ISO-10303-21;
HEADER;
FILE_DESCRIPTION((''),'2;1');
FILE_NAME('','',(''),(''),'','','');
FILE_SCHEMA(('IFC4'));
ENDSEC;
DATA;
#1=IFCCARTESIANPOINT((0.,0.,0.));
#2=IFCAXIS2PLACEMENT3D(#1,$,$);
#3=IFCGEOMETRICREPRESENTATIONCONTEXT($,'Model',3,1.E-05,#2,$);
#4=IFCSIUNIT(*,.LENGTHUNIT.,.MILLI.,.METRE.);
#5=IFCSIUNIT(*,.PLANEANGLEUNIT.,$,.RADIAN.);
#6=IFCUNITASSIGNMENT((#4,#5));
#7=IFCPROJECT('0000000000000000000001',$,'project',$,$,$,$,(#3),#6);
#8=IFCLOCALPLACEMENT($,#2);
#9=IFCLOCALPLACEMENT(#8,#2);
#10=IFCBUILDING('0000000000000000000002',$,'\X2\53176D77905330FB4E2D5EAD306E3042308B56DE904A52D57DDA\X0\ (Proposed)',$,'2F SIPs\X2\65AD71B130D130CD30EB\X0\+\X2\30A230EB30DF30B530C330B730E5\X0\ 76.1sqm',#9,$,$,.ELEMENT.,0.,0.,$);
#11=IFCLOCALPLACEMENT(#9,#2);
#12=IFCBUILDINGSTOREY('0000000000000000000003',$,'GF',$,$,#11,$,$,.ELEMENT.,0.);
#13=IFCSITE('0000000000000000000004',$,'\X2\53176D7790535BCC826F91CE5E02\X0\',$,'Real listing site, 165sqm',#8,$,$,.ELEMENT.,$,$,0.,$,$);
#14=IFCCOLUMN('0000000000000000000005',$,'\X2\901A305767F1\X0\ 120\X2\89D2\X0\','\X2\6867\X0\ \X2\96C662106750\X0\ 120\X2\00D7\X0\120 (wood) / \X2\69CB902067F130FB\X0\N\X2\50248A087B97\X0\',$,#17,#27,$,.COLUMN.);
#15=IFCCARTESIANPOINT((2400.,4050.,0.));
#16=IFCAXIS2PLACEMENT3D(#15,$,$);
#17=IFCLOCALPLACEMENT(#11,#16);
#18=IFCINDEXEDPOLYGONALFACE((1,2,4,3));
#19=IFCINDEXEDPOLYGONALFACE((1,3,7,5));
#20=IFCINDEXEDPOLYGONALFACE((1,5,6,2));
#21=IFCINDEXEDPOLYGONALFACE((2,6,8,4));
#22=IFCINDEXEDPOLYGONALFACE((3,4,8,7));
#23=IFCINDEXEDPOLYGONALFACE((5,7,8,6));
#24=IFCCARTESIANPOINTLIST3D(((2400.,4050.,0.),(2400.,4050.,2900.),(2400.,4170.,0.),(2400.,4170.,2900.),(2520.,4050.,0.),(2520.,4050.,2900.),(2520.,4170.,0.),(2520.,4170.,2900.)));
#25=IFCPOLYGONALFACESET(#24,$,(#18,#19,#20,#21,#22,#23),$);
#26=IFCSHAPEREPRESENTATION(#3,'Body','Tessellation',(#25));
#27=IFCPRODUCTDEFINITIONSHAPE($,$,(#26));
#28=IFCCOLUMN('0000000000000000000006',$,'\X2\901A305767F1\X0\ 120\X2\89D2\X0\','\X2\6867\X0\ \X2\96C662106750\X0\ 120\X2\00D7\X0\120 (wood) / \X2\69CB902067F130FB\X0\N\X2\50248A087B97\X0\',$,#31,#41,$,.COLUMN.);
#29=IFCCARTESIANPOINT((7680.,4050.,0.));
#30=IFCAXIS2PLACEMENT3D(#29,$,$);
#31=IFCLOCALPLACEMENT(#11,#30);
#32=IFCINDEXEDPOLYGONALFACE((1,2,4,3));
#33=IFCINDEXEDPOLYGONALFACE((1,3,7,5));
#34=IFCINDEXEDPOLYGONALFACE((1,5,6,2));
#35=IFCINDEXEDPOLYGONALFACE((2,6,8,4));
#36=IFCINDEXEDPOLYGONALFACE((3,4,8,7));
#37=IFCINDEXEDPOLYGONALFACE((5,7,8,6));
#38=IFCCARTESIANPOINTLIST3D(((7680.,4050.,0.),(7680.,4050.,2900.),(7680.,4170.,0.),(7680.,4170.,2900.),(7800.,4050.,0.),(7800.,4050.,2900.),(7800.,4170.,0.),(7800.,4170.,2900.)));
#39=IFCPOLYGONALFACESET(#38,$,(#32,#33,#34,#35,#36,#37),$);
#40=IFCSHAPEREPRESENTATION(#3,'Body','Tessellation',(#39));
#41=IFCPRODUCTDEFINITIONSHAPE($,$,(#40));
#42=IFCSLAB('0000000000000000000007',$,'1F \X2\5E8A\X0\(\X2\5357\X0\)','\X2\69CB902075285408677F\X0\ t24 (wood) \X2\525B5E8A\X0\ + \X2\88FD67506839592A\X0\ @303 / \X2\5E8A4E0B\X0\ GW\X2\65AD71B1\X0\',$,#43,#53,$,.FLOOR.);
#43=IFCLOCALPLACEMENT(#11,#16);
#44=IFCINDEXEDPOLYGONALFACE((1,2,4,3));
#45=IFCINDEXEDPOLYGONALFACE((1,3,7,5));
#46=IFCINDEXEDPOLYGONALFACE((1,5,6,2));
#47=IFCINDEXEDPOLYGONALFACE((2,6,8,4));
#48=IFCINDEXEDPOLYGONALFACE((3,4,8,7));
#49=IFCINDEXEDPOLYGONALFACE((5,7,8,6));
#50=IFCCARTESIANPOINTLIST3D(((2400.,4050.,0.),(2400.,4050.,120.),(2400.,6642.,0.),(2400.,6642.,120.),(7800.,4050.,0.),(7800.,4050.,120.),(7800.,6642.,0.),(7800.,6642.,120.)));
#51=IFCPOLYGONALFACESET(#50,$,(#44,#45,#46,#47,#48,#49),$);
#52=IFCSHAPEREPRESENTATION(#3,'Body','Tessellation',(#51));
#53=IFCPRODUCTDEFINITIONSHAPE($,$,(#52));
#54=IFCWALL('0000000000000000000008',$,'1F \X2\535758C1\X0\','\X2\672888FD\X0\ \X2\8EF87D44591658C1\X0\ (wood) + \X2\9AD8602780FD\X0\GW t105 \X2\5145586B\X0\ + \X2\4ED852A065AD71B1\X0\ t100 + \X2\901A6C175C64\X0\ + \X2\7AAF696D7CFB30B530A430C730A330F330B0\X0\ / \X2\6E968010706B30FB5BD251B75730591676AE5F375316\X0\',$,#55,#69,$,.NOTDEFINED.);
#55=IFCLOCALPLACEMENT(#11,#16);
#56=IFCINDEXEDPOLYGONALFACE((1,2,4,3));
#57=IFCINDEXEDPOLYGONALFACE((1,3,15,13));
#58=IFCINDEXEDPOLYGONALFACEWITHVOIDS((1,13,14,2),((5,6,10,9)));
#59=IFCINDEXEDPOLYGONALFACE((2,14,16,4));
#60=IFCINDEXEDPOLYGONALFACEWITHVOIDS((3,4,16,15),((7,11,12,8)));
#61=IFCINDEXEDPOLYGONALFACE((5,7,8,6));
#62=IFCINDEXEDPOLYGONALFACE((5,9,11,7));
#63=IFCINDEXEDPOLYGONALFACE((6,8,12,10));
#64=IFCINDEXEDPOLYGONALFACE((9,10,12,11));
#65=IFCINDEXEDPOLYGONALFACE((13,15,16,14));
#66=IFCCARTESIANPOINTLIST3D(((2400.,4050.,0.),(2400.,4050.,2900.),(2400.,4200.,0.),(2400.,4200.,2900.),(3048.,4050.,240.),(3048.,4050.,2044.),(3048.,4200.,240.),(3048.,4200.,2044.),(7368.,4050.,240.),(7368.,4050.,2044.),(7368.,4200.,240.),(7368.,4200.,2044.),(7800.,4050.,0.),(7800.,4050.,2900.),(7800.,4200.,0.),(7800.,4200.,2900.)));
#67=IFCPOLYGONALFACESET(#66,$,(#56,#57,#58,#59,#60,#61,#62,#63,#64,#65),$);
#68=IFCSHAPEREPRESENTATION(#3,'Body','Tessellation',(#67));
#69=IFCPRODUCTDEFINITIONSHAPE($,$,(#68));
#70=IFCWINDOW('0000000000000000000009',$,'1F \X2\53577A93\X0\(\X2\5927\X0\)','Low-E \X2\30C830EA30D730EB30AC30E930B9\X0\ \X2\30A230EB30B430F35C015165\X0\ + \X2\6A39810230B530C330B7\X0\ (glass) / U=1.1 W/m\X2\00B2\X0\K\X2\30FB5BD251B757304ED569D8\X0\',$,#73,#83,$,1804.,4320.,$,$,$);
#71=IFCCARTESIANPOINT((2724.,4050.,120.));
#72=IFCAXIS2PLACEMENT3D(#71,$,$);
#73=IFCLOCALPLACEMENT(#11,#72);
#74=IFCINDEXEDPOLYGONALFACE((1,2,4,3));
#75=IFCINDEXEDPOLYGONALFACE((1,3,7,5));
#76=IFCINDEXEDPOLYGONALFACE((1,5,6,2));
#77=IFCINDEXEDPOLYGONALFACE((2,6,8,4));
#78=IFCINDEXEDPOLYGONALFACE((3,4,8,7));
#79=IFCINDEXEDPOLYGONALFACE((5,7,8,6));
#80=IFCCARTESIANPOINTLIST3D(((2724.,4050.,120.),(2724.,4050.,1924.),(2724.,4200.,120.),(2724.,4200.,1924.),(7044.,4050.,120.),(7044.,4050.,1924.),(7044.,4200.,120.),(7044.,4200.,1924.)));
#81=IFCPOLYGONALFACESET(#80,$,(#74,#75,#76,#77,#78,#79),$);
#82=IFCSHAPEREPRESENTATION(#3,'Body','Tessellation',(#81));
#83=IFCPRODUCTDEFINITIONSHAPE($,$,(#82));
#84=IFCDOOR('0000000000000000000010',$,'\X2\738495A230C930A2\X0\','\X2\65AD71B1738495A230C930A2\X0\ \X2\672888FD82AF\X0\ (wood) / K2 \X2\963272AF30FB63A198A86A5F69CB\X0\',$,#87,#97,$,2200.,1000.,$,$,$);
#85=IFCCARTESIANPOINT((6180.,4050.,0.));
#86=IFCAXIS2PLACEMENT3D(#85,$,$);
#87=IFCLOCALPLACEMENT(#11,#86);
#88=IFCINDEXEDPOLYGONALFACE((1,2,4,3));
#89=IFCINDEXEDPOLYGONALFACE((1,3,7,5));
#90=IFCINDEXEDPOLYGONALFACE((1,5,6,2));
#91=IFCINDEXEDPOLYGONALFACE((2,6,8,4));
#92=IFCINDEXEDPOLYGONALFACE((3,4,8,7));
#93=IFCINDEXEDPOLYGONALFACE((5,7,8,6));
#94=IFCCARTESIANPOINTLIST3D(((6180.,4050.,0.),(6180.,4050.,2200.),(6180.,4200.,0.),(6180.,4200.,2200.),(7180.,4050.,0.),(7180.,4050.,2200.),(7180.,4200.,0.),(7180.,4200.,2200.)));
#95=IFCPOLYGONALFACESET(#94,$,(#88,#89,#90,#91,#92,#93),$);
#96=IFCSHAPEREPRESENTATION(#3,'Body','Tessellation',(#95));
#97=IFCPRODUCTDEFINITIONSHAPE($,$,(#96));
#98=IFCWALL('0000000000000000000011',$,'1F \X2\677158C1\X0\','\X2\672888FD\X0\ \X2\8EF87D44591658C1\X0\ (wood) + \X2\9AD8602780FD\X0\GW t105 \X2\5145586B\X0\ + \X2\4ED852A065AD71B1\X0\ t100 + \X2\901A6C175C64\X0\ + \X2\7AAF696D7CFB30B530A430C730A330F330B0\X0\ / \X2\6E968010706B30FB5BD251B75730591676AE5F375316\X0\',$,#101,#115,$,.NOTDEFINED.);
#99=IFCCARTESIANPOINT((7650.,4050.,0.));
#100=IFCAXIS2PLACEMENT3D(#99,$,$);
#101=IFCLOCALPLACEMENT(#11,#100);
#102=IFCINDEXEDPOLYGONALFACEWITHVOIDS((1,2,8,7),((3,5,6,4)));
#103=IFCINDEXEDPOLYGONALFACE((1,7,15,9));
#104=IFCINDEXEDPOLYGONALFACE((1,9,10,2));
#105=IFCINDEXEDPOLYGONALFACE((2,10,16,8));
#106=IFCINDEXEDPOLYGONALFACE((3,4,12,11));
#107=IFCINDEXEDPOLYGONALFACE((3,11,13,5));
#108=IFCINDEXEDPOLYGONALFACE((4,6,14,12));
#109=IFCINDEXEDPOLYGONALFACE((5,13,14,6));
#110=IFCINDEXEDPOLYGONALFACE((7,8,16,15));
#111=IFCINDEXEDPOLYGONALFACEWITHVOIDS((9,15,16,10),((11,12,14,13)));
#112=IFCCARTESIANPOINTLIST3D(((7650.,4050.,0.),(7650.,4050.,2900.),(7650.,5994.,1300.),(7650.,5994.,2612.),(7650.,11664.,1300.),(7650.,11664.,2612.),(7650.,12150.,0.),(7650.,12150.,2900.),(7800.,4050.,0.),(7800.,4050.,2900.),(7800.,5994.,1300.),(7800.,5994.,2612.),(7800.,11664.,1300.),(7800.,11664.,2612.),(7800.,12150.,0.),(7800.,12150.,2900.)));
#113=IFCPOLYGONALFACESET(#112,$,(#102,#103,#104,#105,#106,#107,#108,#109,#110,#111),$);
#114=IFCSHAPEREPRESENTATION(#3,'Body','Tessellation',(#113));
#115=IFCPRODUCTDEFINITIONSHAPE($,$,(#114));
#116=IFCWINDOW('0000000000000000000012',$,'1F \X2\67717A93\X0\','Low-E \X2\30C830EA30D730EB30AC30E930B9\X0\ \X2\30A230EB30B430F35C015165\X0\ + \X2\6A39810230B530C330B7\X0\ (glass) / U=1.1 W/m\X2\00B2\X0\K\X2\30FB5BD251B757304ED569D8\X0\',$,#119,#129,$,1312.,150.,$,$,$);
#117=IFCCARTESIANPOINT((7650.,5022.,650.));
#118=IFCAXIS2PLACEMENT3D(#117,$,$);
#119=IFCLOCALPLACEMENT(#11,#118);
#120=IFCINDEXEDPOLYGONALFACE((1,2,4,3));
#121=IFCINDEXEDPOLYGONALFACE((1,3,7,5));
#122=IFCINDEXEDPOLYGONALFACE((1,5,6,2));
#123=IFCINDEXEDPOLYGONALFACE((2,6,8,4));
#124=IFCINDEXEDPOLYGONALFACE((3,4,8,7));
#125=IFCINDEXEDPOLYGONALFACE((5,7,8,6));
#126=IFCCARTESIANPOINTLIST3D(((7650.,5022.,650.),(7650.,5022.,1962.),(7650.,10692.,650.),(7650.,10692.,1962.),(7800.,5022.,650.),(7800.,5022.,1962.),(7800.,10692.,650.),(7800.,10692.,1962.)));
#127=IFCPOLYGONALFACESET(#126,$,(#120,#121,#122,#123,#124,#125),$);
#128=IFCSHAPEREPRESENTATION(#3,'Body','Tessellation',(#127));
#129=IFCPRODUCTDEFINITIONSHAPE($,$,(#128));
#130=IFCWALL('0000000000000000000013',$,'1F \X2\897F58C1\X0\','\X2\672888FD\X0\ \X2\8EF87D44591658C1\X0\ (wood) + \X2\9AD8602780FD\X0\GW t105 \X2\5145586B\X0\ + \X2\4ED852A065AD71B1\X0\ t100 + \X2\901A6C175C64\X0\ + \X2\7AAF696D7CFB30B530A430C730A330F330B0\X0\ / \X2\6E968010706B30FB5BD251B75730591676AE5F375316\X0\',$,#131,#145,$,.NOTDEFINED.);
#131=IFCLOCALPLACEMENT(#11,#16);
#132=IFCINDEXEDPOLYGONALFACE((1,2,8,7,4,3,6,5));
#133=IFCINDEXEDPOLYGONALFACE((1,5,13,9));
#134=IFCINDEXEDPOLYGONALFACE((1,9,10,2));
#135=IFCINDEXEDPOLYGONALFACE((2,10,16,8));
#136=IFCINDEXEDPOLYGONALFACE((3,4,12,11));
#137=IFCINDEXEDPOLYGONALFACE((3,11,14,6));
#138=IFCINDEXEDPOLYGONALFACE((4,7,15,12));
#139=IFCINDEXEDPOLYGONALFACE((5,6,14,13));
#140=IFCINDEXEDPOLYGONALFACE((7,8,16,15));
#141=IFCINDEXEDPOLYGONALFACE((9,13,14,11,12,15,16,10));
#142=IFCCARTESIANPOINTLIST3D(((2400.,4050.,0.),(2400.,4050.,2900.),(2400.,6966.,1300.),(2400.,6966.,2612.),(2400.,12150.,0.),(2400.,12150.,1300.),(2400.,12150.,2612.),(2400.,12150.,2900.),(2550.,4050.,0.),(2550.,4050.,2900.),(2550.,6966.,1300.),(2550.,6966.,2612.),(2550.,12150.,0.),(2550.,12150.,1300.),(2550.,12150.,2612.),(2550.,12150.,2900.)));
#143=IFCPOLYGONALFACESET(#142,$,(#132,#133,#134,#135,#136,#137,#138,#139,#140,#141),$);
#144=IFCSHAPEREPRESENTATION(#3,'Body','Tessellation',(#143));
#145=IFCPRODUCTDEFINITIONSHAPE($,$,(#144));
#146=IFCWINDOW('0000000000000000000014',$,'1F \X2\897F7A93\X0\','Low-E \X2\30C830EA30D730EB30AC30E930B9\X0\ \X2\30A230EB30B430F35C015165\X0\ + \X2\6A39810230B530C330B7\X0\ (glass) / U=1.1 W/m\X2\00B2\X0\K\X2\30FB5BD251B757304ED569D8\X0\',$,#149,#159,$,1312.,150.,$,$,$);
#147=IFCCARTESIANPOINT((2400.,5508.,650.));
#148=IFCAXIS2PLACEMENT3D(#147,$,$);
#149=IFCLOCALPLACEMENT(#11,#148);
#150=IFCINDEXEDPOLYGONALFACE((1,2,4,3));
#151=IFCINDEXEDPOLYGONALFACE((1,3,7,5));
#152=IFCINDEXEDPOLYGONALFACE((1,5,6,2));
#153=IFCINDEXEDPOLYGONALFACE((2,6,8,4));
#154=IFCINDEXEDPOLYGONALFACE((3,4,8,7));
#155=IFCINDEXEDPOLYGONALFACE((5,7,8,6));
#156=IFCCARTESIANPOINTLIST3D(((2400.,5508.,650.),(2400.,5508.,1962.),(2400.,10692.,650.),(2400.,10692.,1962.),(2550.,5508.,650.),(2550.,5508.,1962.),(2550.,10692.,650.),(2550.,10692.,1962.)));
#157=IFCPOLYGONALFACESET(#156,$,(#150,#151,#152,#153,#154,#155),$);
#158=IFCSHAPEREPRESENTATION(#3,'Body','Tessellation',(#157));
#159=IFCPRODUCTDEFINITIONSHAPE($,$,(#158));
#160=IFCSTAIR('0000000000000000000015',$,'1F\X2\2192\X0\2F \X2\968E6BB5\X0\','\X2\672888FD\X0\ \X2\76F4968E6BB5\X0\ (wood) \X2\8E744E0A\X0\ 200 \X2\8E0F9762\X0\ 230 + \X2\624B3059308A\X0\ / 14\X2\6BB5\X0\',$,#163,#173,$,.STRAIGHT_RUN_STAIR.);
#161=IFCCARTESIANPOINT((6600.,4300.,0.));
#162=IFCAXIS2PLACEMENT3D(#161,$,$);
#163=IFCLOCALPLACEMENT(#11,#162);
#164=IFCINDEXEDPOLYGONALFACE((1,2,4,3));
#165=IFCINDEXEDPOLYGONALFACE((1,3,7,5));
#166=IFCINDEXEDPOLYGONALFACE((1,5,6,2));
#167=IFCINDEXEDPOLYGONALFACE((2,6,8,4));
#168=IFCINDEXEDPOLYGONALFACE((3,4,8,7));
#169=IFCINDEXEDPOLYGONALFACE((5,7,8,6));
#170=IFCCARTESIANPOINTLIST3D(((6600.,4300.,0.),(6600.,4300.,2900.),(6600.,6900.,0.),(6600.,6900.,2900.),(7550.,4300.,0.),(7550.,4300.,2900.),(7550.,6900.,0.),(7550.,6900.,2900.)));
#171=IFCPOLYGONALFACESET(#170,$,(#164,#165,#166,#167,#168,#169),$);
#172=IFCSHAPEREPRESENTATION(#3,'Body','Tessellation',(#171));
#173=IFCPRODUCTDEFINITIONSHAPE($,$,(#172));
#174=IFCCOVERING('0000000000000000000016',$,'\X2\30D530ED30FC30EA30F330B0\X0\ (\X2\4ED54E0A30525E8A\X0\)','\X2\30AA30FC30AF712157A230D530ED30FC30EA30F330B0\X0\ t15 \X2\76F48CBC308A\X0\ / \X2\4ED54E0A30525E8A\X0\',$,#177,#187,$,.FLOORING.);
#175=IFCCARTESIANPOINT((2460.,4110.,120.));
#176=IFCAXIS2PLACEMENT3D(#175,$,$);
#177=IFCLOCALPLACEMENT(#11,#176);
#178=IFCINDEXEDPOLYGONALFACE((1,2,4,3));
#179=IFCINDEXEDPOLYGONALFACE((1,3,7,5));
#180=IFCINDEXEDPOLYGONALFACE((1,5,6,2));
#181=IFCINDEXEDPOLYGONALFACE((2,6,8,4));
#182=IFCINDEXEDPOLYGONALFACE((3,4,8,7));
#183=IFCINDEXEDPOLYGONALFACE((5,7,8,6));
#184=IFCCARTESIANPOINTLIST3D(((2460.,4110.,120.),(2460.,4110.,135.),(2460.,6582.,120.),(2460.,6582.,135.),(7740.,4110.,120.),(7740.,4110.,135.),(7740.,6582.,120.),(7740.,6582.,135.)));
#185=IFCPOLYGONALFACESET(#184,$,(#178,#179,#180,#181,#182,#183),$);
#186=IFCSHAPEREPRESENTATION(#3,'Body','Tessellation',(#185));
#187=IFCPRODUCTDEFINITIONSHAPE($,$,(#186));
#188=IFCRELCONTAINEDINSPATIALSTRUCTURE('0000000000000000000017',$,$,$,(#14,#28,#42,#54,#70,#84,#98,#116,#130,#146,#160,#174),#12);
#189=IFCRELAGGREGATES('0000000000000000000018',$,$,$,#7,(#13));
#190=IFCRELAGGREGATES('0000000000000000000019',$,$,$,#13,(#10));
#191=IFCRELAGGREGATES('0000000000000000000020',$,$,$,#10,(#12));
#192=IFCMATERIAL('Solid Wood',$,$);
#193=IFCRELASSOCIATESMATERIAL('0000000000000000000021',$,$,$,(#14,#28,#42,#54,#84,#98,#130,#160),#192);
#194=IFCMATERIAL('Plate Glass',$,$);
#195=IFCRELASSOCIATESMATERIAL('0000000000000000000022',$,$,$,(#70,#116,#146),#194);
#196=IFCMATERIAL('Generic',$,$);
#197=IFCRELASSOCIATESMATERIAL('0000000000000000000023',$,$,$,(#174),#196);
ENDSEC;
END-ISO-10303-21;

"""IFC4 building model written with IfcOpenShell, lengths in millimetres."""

from ifc_helpers import new_model, si_unit, frame, frame_2d, origin, place, context, project, spatial, rectangle, extrude, material, element, fill, save


model = new_model("IFC4")

# Units and contexts
model_context = context("Model", 3, precision=1e-05, world=origin())
ifc_project = project(units=[si_unit("LENGTHUNIT", "METRE", prefix="MILLI"), si_unit("PLANEANGLEUNIT", "RADIAN")], contexts=[model_context])

# Site, building, storey
site_placement = place(None, origin())
site = spatial("IfcSite", under=ifc_project, at=site_placement, Name="北海道富良野市", ObjectType="Real listing site, 165sqm", CompositionType="ELEMENT", RefElevation=0.0)
building_placement = place(site_placement, origin())
building = spatial("IfcBuilding", under=site, at=building_placement, Name="北海道・中庭のある回遊動線 (Proposed)", ObjectType="2F SIPs断熱パネル+アルミサッシュ 76.1sqm", CompositionType="ELEMENT", ElevationOfRefHeight=0.0, ElevationOfTerrain=0.0)
storey_placement = place(building_placement, origin())
storey = spatial("IfcBuildingStorey", under=building, at=storey_placement, Name="GF", CompositionType="ELEMENT", Elevation=0.0)

# Columns
ifc_material_1 = material(Name="Solid Wood")
column_1_placement = place(storey_placement, frame((2400.0, 4050.0, 0.0)))
element("IfcColumn", 1, at=column_1_placement, inside=storey, material=ifc_material_1, Name="通し柱 120角", Description="桧 集成材 120×120 (wood) / 構造柱・N値計算", PredefinedType="COLUMN", context=model_context, shape_type="SweptSolid", body=[
    extrude(rectangle(XDim=120.0, YDim=120.0, at=frame_2d((60.0, 60.0))), frame((2400.0, 4050.0, 0.0)), (0.0, 0.0, 1.0), 2900.0),
])
column_2_placement = place(storey_placement, frame((7680.0, 4050.0, 0.0)))
element("IfcColumn", 2, at=column_2_placement, inside=storey, material=ifc_material_1, Name="通し柱 120角", Description="桧 集成材 120×120 (wood) / 構造柱・N値計算", PredefinedType="COLUMN", context=model_context, shape_type="SweptSolid", body=[
    extrude(rectangle(XDim=120.0, YDim=120.0, at=frame_2d((60.0, 60.0))), frame((7680.0, 4050.0, 0.0)), (0.0, 0.0, 1.0), 2900.0),
])

# Slab
slab_1_placement = place(storey_placement, frame((2400.0, 4050.0, 0.0)))
element("IfcSlab", 3, at=slab_1_placement, inside=storey, material=ifc_material_1, Name="1F 床(南)", Description="構造用合板 t24 (wood) 剛床 + 製材根太 @303 / 床下 GW断熱", PredefinedType="FLOOR", context=model_context, shape_type="SweptSolid", body=[
    extrude(rectangle(XDim=5400.0, YDim=2592.0, at=frame_2d((2700.0, 1296.0))), frame((2400.0, 4050.0, 0.0)), (0.0, 0.0, 1.0), 120.0),
])

# Wall, openings, window, door
wall_1_placement = place(storey_placement, frame((2400.0, 4050.0, 0.0)))
wall_1 = element("IfcWall", 4, at=wall_1_placement, inside=storey, material=ifc_material_1, Name="1F 南壁", Description="木製 軸組外壁 (wood) + 高性能GW t105 充填 + 付加断熱 t100 + 通気層 + 窯業系サイディング / 準耐火・寒冷地外皮強化", PredefinedType="NOTDEFINED", context=model_context, shape_type="SweptSolid", body=[
    extrude(rectangle(XDim=5400.0, YDim=150.0, at=frame_2d((2700.0, 75.0))), frame((2400.0, 4050.0, 0.0)), (0.0, 0.0, 1.0), 2900.0),
])
opening_1_placement = place(storey_placement, frame((2724.0, 4050.0, 120.0)))
opening_1 = element("IfcOpeningElement", 5, at=opening_1_placement, cuts=wall_1, PredefinedType="NOTDEFINED", context=model_context, shape_type="SweptSolid", body=[
    extrude(rectangle(XDim=4320.0, YDim=150.0, at=frame_2d((2160.0, 75.0))), frame((2724.0, 4050.0, 120.0)), (0.0, 0.0, 1.0), 1804.0),
])
opening_2_placement = place(storey_placement, frame((6180.0, 4050.0, 0.0)))
opening_2 = element("IfcOpeningElement", 6, at=opening_2_placement, cuts=wall_1, PredefinedType="NOTDEFINED", context=model_context, shape_type="SweptSolid", body=[
    extrude(rectangle(XDim=1000.0, YDim=150.0, at=frame_2d((500.0, 75.0))), frame((6180.0, 4050.0, 0.0)), (0.0, 0.0, 1.0), 2200.0),
])
ifc_material_2 = material(Name="Plate Glass")
window_1_placement = place(storey_placement, frame((2724.0, 4050.0, 120.0)))
window_1 = element("IfcWindow", 7, at=window_1_placement, inside=storey, material=ifc_material_2, Name="1F 南窓(大)", Description="Low-E トリプルガラス アルゴン封入 + 樹脂サッシ (glass) / U=1.1 W/m²K・寒冷地仕様", OverallHeight=1804.0, OverallWidth=4320.0, context=model_context, shape_type="SweptSolid", body=[
    extrude(rectangle(XDim=4320.0, YDim=150.0, at=frame_2d((2160.0, 75.0))), frame((2724.0, 4050.0, 120.0)), (0.0, 0.0, 1.0), 1804.0),
])
fill(opening_1, window_1)
door_placement = place(storey_placement, frame((6180.0, 4050.0, 0.0)))
door = element("IfcDoor", 8, at=door_placement, inside=storey, material=ifc_material_1, Name="玄関ドア", Description="断熱玄関ドア 木製芯 (wood) / K2 防犯・採風機構", OverallHeight=2200.0, OverallWidth=1000.0, context=model_context, shape_type="SweptSolid", body=[
    extrude(rectangle(XDim=1000.0, YDim=150.0, at=frame_2d((500.0, 75.0))), frame((6180.0, 4050.0, 0.0)), (0.0, 0.0, 1.0), 2200.0),
])
fill(opening_2, door)

# Walls, openings, windows
wall_2_placement = place(storey_placement, frame((7650.0, 4050.0, 0.0)))
wall_2 = element("IfcWall", 9, at=wall_2_placement, inside=storey, material=ifc_material_1, Name="1F 東壁", Description="木製 軸組外壁 (wood) + 高性能GW t105 充填 + 付加断熱 t100 + 通気層 + 窯業系サイディング / 準耐火・寒冷地外皮強化", PredefinedType="NOTDEFINED", context=model_context, shape_type="SweptSolid", body=[
    extrude(rectangle(XDim=150.0, YDim=8100.0, at=frame_2d((75.0, 4050.0))), frame((7650.0, 4050.0, 0.0)), (0.0, 0.0, 1.0), 2900.0),
])
opening_3_placement = place(storey_placement, frame((7650.0, 5022.0, 650.0)))
opening_3 = element("IfcOpeningElement", 10, at=opening_3_placement, cuts=wall_2, PredefinedType="NOTDEFINED", context=model_context, shape_type="SweptSolid", body=[
    extrude(rectangle(XDim=150.0, YDim=5670.0, at=frame_2d((75.0, 2835.0))), frame((7650.0, 5022.0, 650.0)), (0.0, 0.0, 1.0), 1312.0),
])
window_2_placement = place(storey_placement, frame((7650.0, 5022.0, 650.0)))
window_2 = element("IfcWindow", 11, at=window_2_placement, inside=storey, material=ifc_material_2, Name="1F 東窓", Description="Low-E トリプルガラス アルゴン封入 + 樹脂サッシ (glass) / U=1.1 W/m²K・寒冷地仕様", OverallHeight=1312.0, OverallWidth=150.0, context=model_context, shape_type="SweptSolid", body=[
    extrude(rectangle(XDim=150.0, YDim=5670.0, at=frame_2d((75.0, 2835.0))), frame((7650.0, 5022.0, 650.0)), (0.0, 0.0, 1.0), 1312.0),
])
fill(opening_3, window_2)
wall_3_placement = place(storey_placement, frame((2400.0, 4050.0, 0.0)))
wall_3 = element("IfcWall", 12, at=wall_3_placement, inside=storey, material=ifc_material_1, Name="1F 西壁", Description="木製 軸組外壁 (wood) + 高性能GW t105 充填 + 付加断熱 t100 + 通気層 + 窯業系サイディング / 準耐火・寒冷地外皮強化", PredefinedType="NOTDEFINED", context=model_context, shape_type="SweptSolid", body=[
    extrude(rectangle(XDim=150.0, YDim=8100.0, at=frame_2d((75.0, 4050.0))), frame((2400.0, 4050.0, 0.0)), (0.0, 0.0, 1.0), 2900.0),
])
opening_4_placement = place(storey_placement, frame((2400.0, 5508.0, 650.0)))
opening_4 = element("IfcOpeningElement", 13, at=opening_4_placement, cuts=wall_3, PredefinedType="NOTDEFINED", context=model_context, shape_type="SweptSolid", body=[
    extrude(rectangle(XDim=150.0, YDim=5184.0, at=frame_2d((75.0, 2592.0))), frame((2400.0, 5508.0, 650.0)), (0.0, 0.0, 1.0), 1312.0),
])
window_3_placement = place(storey_placement, frame((2400.0, 5508.0, 650.0)))
window_3 = element("IfcWindow", 14, at=window_3_placement, inside=storey, material=ifc_material_2, Name="1F 西窓", Description="Low-E トリプルガラス アルゴン封入 + 樹脂サッシ (glass) / U=1.1 W/m²K・寒冷地仕様", OverallHeight=1312.0, OverallWidth=150.0, context=model_context, shape_type="SweptSolid", body=[
    extrude(rectangle(XDim=150.0, YDim=5184.0, at=frame_2d((75.0, 2592.0))), frame((2400.0, 5508.0, 650.0)), (0.0, 0.0, 1.0), 1312.0),
])
fill(opening_4, window_3)

# Stair
stair_placement = place(storey_placement, frame((6600.0, 4300.0, 0.0)))
element("IfcStair", 15, at=stair_placement, inside=storey, material=ifc_material_1, Name="1F→2F 階段", Description="木製 直階段 (wood) 蹴上 200 踏面 230 + 手すり / 14段", PredefinedType="STRAIGHT_RUN_STAIR", context=model_context, shape_type="SweptSolid", body=[
    extrude(rectangle(XDim=950.0, YDim=2600.0, at=frame_2d((475.0, 1300.0))), frame((6600.0, 4300.0, 0.0)), (0.0, 0.0, 1.0), 2900.0),
])

# Covering
ifc_material_3 = material(Name="Generic")
covering_1_placement = place(storey_placement, frame((2460.0, 4110.0, 120.0)))
element("IfcCovering", 16, at=covering_1_placement, inside=storey, material=ifc_material_3, Name="フローリング (仕上げ床)", Description="オーク無垢フローリング t15 直貼り / 仕上げ床", PredefinedType="FLOORING", context=model_context, shape_type="SweptSolid", body=[
    extrude(rectangle(XDim=5280.0, YDim=2472.0, at=frame_2d((2640.0, 1236.0))), frame((2460.0, 4110.0, 120.0)), (0.0, 0.0, 1.0), 15.0),
])

save(model, "model.ifc")
